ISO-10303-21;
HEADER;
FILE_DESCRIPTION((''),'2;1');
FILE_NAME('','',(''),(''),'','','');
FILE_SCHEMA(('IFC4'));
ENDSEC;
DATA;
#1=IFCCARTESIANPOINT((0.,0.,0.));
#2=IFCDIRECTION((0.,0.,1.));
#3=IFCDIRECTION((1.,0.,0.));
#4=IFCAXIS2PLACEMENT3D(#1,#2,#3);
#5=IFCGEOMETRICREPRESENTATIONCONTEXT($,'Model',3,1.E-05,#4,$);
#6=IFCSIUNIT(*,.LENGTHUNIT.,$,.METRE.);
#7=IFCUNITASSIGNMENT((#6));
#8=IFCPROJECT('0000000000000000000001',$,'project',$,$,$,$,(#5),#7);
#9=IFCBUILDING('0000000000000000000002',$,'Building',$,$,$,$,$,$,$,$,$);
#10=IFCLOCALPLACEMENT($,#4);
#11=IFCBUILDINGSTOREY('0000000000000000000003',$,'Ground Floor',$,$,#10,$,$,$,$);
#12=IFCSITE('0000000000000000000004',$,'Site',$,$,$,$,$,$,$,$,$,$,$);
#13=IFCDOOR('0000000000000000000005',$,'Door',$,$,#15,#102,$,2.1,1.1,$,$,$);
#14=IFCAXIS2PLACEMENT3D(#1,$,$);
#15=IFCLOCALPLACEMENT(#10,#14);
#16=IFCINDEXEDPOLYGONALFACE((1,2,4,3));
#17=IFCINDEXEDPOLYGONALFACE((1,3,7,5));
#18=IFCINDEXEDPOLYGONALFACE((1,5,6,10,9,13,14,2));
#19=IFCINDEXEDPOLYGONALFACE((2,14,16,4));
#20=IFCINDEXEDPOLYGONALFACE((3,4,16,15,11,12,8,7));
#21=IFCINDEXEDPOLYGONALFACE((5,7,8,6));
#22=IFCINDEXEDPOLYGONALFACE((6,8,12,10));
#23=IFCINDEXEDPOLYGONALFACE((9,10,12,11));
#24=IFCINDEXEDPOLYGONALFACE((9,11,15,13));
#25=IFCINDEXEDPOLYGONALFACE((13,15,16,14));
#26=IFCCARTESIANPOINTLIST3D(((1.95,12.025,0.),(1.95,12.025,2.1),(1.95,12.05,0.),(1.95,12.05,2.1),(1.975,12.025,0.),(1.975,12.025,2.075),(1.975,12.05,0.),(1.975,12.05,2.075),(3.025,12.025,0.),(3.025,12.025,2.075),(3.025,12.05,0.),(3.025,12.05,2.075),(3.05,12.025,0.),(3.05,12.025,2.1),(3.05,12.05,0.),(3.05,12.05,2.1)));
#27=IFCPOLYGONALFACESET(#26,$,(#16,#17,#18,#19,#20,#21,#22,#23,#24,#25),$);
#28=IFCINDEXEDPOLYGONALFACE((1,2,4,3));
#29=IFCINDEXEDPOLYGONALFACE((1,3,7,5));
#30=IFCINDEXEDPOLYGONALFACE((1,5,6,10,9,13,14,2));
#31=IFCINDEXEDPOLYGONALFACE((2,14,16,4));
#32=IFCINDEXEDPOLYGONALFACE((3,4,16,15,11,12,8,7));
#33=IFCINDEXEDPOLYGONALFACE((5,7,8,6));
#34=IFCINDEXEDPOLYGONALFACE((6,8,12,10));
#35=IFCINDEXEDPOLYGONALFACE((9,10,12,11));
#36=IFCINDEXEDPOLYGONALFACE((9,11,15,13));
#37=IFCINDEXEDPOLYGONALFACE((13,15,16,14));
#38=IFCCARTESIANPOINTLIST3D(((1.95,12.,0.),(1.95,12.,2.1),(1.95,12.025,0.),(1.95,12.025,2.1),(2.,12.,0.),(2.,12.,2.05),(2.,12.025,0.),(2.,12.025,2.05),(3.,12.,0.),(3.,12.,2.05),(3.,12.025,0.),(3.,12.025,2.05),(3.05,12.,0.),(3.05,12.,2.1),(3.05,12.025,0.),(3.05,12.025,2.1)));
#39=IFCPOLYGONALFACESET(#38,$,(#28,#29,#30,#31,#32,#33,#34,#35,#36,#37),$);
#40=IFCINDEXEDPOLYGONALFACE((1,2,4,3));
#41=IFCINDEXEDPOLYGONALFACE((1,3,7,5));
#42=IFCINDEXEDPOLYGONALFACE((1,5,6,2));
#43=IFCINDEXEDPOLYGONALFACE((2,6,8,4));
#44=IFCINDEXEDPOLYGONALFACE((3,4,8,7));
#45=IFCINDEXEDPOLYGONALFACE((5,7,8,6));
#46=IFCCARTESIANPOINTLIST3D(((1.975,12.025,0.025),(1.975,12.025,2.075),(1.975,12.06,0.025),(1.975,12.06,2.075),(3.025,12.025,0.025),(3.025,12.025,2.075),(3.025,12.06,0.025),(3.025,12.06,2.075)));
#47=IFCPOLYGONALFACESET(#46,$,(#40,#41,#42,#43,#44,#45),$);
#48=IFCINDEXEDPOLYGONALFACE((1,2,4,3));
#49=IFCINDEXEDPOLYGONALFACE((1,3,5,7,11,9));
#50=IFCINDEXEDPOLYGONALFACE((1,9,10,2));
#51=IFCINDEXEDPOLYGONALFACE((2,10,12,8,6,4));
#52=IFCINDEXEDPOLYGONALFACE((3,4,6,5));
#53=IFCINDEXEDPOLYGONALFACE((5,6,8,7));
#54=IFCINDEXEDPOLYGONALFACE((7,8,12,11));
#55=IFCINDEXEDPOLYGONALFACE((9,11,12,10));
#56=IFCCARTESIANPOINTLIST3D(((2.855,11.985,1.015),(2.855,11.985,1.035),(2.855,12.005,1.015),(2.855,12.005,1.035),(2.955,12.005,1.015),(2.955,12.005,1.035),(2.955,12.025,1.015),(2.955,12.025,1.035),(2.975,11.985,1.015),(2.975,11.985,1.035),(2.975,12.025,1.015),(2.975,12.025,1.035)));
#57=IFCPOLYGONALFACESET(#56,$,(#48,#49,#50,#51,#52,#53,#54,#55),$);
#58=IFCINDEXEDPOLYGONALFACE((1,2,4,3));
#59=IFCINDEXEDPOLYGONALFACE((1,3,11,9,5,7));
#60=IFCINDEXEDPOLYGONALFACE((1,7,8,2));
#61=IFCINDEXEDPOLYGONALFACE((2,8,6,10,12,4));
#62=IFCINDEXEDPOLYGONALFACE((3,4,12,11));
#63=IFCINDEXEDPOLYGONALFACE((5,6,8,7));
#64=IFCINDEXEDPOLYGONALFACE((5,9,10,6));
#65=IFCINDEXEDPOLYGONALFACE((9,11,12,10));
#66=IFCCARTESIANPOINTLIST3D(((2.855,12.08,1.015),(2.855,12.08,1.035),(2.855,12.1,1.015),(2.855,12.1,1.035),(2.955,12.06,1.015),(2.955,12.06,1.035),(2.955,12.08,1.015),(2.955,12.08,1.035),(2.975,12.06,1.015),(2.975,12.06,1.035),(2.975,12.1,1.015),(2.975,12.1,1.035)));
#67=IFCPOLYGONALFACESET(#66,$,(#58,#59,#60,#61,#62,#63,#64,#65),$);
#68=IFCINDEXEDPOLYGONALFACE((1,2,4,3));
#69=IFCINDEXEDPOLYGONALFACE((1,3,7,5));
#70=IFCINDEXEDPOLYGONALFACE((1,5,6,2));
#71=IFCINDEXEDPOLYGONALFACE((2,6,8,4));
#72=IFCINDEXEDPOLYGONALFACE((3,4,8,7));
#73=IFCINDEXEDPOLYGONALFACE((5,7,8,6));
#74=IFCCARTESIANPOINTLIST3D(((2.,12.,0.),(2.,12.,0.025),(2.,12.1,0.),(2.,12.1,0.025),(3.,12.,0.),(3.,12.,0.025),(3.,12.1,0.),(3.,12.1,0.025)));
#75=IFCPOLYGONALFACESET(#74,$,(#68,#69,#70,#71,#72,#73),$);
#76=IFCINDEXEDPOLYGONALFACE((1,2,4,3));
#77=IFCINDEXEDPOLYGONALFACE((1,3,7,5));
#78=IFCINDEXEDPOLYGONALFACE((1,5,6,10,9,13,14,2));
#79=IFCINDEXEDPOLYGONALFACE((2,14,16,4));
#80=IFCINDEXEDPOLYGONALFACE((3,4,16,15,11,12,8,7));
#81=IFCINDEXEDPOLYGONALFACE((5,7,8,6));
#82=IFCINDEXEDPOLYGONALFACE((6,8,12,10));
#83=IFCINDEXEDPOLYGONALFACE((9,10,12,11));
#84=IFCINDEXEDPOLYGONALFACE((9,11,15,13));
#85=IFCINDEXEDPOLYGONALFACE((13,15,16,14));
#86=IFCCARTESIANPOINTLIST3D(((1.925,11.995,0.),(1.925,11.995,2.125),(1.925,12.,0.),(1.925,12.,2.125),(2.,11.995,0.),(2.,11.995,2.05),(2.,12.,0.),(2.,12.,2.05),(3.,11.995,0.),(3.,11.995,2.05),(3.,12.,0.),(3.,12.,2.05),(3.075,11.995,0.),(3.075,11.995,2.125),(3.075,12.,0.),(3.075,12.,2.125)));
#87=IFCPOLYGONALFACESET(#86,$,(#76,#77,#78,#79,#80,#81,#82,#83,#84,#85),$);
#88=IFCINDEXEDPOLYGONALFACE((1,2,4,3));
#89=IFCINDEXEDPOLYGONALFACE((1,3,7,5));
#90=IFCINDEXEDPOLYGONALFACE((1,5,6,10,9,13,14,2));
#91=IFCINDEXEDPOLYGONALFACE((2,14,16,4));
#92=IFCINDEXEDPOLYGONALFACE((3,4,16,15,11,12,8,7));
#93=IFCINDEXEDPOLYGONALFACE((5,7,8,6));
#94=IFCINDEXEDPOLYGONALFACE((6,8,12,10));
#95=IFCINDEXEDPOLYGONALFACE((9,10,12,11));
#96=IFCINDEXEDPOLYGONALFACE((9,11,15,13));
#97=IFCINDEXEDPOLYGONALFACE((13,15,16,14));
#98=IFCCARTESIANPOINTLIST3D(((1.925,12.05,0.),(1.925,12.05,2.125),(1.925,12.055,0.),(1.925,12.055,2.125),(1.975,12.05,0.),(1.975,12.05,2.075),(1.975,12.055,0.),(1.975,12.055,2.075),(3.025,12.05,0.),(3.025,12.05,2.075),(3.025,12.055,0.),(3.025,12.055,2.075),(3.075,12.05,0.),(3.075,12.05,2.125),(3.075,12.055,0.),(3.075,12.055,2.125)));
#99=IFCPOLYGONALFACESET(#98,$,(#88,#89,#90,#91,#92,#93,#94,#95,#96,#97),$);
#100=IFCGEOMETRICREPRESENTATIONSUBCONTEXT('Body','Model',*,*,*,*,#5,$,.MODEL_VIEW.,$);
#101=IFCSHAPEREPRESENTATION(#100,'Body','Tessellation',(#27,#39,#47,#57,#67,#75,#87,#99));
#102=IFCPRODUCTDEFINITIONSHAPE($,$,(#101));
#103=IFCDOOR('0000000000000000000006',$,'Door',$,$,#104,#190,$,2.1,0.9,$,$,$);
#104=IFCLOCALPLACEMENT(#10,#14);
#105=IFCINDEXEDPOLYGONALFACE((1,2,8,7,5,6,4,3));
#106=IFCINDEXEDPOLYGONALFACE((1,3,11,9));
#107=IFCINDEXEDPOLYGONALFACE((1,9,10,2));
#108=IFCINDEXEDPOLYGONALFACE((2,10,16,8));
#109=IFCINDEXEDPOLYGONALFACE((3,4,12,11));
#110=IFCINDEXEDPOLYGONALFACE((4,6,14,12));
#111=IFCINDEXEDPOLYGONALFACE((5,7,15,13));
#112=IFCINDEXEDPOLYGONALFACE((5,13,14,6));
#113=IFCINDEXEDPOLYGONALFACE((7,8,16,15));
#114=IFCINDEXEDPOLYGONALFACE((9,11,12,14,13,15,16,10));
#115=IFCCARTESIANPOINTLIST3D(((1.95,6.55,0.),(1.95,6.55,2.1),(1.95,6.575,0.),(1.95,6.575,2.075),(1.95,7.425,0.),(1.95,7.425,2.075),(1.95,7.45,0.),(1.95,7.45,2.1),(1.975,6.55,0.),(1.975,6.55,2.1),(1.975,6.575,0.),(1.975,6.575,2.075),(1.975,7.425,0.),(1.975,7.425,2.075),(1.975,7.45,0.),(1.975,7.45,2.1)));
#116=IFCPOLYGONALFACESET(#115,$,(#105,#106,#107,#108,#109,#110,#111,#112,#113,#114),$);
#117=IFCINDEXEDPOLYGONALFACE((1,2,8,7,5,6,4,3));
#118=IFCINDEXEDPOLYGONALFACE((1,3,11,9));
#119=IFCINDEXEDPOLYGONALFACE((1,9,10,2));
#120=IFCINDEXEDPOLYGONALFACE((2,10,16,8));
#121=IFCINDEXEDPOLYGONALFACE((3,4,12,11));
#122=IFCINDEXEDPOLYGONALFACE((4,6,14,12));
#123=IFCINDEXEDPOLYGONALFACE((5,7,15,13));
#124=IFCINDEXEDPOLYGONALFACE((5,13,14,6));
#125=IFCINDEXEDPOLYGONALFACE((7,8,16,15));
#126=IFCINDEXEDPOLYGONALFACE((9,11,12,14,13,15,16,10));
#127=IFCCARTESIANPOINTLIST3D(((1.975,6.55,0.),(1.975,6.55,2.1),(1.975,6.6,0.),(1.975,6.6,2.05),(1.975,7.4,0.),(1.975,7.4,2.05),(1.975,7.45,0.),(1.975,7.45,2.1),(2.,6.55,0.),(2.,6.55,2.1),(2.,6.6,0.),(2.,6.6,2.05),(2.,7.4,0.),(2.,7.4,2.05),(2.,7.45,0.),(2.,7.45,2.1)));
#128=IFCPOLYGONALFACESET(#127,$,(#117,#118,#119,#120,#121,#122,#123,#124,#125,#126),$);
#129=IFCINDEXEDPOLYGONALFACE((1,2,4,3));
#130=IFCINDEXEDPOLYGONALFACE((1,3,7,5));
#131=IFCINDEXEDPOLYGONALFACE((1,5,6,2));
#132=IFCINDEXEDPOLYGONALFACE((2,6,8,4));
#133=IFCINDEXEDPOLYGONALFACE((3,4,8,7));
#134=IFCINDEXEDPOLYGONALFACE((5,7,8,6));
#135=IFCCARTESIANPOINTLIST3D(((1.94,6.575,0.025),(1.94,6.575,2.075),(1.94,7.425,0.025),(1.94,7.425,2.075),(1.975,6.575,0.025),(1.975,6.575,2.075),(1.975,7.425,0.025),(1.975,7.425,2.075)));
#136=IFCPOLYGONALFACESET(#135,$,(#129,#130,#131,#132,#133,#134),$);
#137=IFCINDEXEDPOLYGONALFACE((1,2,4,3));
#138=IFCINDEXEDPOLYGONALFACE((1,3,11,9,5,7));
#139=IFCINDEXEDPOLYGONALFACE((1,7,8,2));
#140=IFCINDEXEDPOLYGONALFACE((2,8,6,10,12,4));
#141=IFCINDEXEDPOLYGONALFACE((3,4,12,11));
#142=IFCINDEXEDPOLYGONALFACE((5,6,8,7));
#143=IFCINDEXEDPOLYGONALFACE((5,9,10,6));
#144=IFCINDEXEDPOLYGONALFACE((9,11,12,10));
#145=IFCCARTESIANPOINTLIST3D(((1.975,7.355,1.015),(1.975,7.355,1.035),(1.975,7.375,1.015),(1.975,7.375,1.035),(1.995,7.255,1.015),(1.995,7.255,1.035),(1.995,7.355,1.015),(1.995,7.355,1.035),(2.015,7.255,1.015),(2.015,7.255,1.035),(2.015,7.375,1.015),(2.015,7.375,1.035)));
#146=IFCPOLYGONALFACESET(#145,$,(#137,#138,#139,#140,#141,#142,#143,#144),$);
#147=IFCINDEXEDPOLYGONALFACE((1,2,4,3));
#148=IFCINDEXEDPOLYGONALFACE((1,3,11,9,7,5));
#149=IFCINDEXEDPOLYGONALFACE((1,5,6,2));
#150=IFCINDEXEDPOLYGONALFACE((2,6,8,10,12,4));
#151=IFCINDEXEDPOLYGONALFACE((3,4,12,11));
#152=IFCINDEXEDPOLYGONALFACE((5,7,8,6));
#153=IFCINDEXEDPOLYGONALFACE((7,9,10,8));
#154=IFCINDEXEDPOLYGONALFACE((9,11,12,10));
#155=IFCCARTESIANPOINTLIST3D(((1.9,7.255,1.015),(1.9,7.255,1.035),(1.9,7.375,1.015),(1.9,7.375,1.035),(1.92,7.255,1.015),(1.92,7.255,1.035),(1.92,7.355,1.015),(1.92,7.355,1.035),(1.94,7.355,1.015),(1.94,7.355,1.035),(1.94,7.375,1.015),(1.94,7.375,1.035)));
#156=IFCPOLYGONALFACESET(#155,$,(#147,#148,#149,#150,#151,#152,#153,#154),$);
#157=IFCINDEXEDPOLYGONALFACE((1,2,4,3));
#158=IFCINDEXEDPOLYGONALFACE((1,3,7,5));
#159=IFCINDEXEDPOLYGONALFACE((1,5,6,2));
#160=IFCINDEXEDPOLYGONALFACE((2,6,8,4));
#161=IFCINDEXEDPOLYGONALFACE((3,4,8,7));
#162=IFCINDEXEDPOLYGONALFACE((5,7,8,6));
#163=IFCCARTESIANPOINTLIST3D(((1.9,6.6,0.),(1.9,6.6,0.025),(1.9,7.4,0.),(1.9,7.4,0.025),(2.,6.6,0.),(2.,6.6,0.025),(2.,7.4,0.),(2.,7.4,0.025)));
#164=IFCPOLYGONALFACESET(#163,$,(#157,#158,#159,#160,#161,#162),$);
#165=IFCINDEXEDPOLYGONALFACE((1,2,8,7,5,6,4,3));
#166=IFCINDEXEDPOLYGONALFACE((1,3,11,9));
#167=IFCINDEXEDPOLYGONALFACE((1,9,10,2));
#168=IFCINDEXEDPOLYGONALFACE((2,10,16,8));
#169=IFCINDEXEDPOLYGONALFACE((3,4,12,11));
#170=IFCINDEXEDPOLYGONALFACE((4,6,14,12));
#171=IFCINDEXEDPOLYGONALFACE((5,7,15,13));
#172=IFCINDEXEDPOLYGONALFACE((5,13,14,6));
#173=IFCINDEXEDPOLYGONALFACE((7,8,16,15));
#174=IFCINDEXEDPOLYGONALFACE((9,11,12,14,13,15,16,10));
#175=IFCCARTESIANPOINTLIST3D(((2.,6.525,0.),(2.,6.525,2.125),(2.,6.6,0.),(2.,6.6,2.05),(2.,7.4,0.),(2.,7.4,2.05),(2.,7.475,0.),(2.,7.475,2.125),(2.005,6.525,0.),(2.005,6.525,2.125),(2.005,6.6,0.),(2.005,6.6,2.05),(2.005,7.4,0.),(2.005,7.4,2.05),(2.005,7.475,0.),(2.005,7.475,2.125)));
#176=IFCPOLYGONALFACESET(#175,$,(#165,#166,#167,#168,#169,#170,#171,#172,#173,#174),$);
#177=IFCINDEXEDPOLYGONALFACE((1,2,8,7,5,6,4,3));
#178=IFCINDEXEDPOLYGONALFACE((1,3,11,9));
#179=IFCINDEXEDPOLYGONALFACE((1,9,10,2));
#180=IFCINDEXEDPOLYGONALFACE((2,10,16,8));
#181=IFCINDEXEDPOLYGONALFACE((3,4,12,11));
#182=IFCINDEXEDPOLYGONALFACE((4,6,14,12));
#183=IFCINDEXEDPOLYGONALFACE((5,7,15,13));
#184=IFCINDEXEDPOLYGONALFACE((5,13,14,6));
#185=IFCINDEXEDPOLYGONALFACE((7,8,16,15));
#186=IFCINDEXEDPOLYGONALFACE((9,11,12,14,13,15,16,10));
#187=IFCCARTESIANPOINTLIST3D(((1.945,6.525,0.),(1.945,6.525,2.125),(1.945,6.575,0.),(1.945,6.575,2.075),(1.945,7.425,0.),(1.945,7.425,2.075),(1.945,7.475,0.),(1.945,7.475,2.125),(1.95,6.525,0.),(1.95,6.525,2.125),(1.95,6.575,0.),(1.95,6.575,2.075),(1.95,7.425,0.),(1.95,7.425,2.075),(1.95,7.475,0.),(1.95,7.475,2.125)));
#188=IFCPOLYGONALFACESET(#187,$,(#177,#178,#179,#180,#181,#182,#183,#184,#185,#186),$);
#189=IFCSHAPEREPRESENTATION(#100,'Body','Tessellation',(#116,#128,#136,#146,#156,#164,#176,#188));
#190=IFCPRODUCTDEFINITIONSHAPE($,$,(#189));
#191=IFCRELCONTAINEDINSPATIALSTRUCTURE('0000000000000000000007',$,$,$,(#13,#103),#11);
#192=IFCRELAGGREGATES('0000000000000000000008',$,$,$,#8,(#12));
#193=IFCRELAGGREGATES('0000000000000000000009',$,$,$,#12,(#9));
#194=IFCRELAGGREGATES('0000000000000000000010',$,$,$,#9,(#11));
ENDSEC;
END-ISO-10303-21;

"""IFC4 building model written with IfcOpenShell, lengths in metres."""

from ifc_helpers import new_model, si_unit, frame, origin_with_axes, place, context, subcontext, project, spatial, line, indexed_curve, outline, extrude, element, save


model = new_model("IFC4")

# Units and contexts
model_context = context("Model", 3, precision=1e-05, world=origin_with_axes())
body_context = subcontext(model_context, "Body", "Model", "MODEL_VIEW")
ifc_project = project(units=[si_unit("LENGTHUNIT", "METRE")], contexts=[model_context])

# Site, building, storey
site = spatial("IfcSite", under=ifc_project, Name="Site")
building = spatial("IfcBuilding", under=site, Name="Building")
storey_placement = place(None, origin_with_axes())
storey = spatial("IfcBuildingStorey", under=building, at=storey_placement, Name="Ground Floor")

# Doors
door_1_placement = place(storey_placement, frame((1.95, 12.0, 0.0), z_axis=(0.0, 0.0, 1.0), x_axis=(1.0, 0.0, 0.0)))
element("IfcDoor", 1, at=door_1_placement, inside=storey, Name="Door", OverallHeight=2.1, OverallWidth=1.1, context=body_context, shape_type="SweptSolid", body=[
    extrude(outline(indexed_curve([(0.0, 0.0), (0.0, 2.1), (1.1, 2.1), (1.1, 0.0), (1.075, 0.0), (1.075, 2.075), (0.025, 2.075), (0.025, 0.0)], segments=[line(1, 2, 3, 4, 5, 6, 7, 8, 1)])), frame((0.0, 0.025, 0.0), z_axis=(0.0, -1.0, 0.0), x_axis=(1.0, 0.0, 0.0)), (0.0, 0.0, -1.0), 0.025),
    extrude(outline(indexed_curve([(0.0, 0.0), (0.0, 2.1), (1.1, 2.1), (1.1, 0.0), (1.05, 0.0), (1.05, 2.05), (0.05, 2.05), (0.05, 0.0)], segments=[line(1, 2, 3, 4, 5, 6, 7, 8, 1)])), frame((0.0, 0.0, 0.0), z_axis=(0.0, -1.0, 0.0), x_axis=(1.0, 0.0, 0.0)), (0.0, 0.0, -1.0), 0.025),
    extrude(outline(indexed_curve([(0.0, 0.0), (1.05, 0.0), (1.05, 0.035), (0.0, 0.035)], segments=[line(1, 2, 3, 4, 1)])), frame((0.025, 0.025, 0.025), z_axis=(0.0, 0.0, 1.0), x_axis=(1.0, 0.0, 0.0)), (0.0, 0.0, 1.0), 2.05),
    extrude(outline(indexed_curve([(0.0, 0.0), (0.0, -0.04), (-0.12, -0.04), (-0.12, -0.02), (-0.02, -0.02), (-0.02, 0.0)], segments=[line(1, 2, 3, 4, 5, 6, 1)])), frame((1.025, 0.025, 1.015), z_axis=(0.0, 0.0, 1.0), x_axis=(1.0, 0.0, 0.0)), (0.0, 0.0, 1.0), 0.02),
    extrude(outline(indexed_curve([(0.0, 0.0), (0.0, 0.04), (-0.12, 0.04), (-0.12, 0.02), (-0.02, 0.02), (-0.02, 0.0)], segments=[line(1, 2, 3, 4, 5, 6, 1)])), frame((1.025, 0.06, 1.015), z_axis=(0.0, 0.0, 1.0), x_axis=(1.0, 0.0, 0.0)), (0.0, 0.0, 1.0), 0.02),
    extrude(outline(indexed_curve([(0.0, 0.0), (1.0, 0.0), (1.0, 0.1), (0.0, 0.1)], segments=[line(1, 2, 3, 4, 1)])), frame((0.05, 0.0, 0.0), z_axis=(0.0, 0.0, 1.0), x_axis=(1.0, 0.0, 0.0)), (0.0, 0.0, 1.0), 0.025),
    extrude(outline(indexed_curve([(0.0, 0.0), (0.0, 2.125), (1.15, 2.125), (1.15, 0.0), (1.075, 0.0), (1.075, 2.05), (0.075, 2.05), (0.075, 0.0)], segments=[line(1, 2, 3, 4, 5, 6, 7, 8, 1)])), frame((-0.025, -0.005, 0.0), z_axis=(0.0, -1.0, 0.0), x_axis=(1.0, 0.0, 0.0)), (0.0, 0.0, -1.0), 0.005),
    extrude(outline(indexed_curve([(0.0, 0.0), (0.0, 2.125), (1.15, 2.125), (1.15, 0.0), (1.1, 0.0), (1.1, 2.075), (0.05, 2.075), (0.05, 0.0)], segments=[line(1, 2, 3, 4, 5, 6, 7, 8, 1)])), frame((-0.025, 0.05, 0.0), z_axis=(0.0, -1.0, 0.0), x_axis=(1.0, 0.0, 0.0)), (0.0, 0.0, -1.0), 0.005),
])
door_2_placement = place(storey_placement, frame((2.0, 6.55, 0.0), z_axis=(0.0, 0.0, 1.0), x_axis=(0.0, 1.0, 0.0)))
element("IfcDoor", 2, at=door_2_placement, inside=storey, Name="Door", OverallHeight=2.1, OverallWidth=0.9, context=body_context, shape_type="SweptSolid", body=[
    extrude(outline(indexed_curve([(0.0, 0.0), (0.0, 2.1), (0.9, 2.1), (0.9, 0.0), (0.875, 0.0), (0.875, 2.075), (0.025, 2.075), (0.025, 0.0)], segments=[line(1, 2, 3, 4, 5, 6, 7, 8, 1)])), frame((0.0, 0.025, 0.0), z_axis=(0.0, -1.0, 0.0), x_axis=(1.0, 0.0, 0.0)), (0.0, 0.0, -1.0), 0.025),
    extrude(outline(indexed_curve([(0.0, 0.0), (0.0, 2.1), (0.9, 2.1), (0.9, 0.0), (0.85, 0.0), (0.85, 2.05), (0.05, 2.05), (0.05, 0.0)], segments=[line(1, 2, 3, 4, 5, 6, 7, 8, 1)])), frame((0.0, 0.0, 0.0), z_axis=(0.0, -1.0, 0.0), x_axis=(1.0, 0.0, 0.0)), (0.0, 0.0, -1.0), 0.025),
    extrude(outline(indexed_curve([(0.0, 0.0), (0.85, 0.0), (0.85, 0.035), (0.0, 0.035)], segments=[line(1, 2, 3, 4, 1)])), frame((0.025, 0.025, 0.025), z_axis=(0.0, 0.0, 1.0), x_axis=(1.0, 0.0, 0.0)), (0.0, 0.0, 1.0), 2.05),
    extrude(outline(indexed_curve([(0.0, 0.0), (0.0, -0.04), (-0.12, -0.04), (-0.12, -0.02), (-0.02, -0.02), (-0.02, 0.0)], segments=[line(1, 2, 3, 4, 5, 6, 1)])), frame((0.825, 0.025, 1.015), z_axis=(0.0, 0.0, 1.0), x_axis=(1.0, 0.0, 0.0)), (0.0, 0.0, 1.0), 0.02),
    extrude(outline(indexed_curve([(0.0, 0.0), (0.0, 0.04), (-0.12, 0.04), (-0.12, 0.02), (-0.02, 0.02), (-0.02, 0.0)], segments=[line(1, 2, 3, 4, 5, 6, 1)])), frame((0.825, 0.06, 1.015), z_axis=(0.0, 0.0, 1.0), x_axis=(1.0, 0.0, 0.0)), (0.0, 0.0, 1.0), 0.02),
    extrude(outline(indexed_curve([(0.0, 0.0), (0.8, 0.0), (0.8, 0.1), (0.0, 0.1)], segments=[line(1, 2, 3, 4, 1)])), frame((0.05, 0.0, 0.0), z_axis=(0.0, 0.0, 1.0), x_axis=(1.0, 0.0, 0.0)), (0.0, 0.0, 1.0), 0.025),
    extrude(outline(indexed_curve([(0.0, 0.0), (0.0, 2.125), (0.95, 2.125), (0.95, 0.0), (0.875, 0.0), (0.875, 2.05), (0.075, 2.05), (0.075, 0.0)], segments=[line(1, 2, 3, 4, 5, 6, 7, 8, 1)])), frame((-0.025, -0.005, 0.0), z_axis=(0.0, -1.0, 0.0), x_axis=(1.0, 0.0, 0.0)), (0.0, 0.0, -1.0), 0.005),
    extrude(outline(indexed_curve([(0.0, 0.0), (0.0, 2.125), (0.95, 2.125), (0.95, 0.0), (0.9, 0.0), (0.9, 2.075), (0.05, 2.075), (0.05, 0.0)], segments=[line(1, 2, 3, 4, 5, 6, 7, 8, 1)])), frame((-0.025, 0.05, 0.0), z_axis=(0.0, -1.0, 0.0), x_axis=(1.0, 0.0, 0.0)), (0.0, 0.0, -1.0), 0.005),
])

save(model, "model.ifc")
